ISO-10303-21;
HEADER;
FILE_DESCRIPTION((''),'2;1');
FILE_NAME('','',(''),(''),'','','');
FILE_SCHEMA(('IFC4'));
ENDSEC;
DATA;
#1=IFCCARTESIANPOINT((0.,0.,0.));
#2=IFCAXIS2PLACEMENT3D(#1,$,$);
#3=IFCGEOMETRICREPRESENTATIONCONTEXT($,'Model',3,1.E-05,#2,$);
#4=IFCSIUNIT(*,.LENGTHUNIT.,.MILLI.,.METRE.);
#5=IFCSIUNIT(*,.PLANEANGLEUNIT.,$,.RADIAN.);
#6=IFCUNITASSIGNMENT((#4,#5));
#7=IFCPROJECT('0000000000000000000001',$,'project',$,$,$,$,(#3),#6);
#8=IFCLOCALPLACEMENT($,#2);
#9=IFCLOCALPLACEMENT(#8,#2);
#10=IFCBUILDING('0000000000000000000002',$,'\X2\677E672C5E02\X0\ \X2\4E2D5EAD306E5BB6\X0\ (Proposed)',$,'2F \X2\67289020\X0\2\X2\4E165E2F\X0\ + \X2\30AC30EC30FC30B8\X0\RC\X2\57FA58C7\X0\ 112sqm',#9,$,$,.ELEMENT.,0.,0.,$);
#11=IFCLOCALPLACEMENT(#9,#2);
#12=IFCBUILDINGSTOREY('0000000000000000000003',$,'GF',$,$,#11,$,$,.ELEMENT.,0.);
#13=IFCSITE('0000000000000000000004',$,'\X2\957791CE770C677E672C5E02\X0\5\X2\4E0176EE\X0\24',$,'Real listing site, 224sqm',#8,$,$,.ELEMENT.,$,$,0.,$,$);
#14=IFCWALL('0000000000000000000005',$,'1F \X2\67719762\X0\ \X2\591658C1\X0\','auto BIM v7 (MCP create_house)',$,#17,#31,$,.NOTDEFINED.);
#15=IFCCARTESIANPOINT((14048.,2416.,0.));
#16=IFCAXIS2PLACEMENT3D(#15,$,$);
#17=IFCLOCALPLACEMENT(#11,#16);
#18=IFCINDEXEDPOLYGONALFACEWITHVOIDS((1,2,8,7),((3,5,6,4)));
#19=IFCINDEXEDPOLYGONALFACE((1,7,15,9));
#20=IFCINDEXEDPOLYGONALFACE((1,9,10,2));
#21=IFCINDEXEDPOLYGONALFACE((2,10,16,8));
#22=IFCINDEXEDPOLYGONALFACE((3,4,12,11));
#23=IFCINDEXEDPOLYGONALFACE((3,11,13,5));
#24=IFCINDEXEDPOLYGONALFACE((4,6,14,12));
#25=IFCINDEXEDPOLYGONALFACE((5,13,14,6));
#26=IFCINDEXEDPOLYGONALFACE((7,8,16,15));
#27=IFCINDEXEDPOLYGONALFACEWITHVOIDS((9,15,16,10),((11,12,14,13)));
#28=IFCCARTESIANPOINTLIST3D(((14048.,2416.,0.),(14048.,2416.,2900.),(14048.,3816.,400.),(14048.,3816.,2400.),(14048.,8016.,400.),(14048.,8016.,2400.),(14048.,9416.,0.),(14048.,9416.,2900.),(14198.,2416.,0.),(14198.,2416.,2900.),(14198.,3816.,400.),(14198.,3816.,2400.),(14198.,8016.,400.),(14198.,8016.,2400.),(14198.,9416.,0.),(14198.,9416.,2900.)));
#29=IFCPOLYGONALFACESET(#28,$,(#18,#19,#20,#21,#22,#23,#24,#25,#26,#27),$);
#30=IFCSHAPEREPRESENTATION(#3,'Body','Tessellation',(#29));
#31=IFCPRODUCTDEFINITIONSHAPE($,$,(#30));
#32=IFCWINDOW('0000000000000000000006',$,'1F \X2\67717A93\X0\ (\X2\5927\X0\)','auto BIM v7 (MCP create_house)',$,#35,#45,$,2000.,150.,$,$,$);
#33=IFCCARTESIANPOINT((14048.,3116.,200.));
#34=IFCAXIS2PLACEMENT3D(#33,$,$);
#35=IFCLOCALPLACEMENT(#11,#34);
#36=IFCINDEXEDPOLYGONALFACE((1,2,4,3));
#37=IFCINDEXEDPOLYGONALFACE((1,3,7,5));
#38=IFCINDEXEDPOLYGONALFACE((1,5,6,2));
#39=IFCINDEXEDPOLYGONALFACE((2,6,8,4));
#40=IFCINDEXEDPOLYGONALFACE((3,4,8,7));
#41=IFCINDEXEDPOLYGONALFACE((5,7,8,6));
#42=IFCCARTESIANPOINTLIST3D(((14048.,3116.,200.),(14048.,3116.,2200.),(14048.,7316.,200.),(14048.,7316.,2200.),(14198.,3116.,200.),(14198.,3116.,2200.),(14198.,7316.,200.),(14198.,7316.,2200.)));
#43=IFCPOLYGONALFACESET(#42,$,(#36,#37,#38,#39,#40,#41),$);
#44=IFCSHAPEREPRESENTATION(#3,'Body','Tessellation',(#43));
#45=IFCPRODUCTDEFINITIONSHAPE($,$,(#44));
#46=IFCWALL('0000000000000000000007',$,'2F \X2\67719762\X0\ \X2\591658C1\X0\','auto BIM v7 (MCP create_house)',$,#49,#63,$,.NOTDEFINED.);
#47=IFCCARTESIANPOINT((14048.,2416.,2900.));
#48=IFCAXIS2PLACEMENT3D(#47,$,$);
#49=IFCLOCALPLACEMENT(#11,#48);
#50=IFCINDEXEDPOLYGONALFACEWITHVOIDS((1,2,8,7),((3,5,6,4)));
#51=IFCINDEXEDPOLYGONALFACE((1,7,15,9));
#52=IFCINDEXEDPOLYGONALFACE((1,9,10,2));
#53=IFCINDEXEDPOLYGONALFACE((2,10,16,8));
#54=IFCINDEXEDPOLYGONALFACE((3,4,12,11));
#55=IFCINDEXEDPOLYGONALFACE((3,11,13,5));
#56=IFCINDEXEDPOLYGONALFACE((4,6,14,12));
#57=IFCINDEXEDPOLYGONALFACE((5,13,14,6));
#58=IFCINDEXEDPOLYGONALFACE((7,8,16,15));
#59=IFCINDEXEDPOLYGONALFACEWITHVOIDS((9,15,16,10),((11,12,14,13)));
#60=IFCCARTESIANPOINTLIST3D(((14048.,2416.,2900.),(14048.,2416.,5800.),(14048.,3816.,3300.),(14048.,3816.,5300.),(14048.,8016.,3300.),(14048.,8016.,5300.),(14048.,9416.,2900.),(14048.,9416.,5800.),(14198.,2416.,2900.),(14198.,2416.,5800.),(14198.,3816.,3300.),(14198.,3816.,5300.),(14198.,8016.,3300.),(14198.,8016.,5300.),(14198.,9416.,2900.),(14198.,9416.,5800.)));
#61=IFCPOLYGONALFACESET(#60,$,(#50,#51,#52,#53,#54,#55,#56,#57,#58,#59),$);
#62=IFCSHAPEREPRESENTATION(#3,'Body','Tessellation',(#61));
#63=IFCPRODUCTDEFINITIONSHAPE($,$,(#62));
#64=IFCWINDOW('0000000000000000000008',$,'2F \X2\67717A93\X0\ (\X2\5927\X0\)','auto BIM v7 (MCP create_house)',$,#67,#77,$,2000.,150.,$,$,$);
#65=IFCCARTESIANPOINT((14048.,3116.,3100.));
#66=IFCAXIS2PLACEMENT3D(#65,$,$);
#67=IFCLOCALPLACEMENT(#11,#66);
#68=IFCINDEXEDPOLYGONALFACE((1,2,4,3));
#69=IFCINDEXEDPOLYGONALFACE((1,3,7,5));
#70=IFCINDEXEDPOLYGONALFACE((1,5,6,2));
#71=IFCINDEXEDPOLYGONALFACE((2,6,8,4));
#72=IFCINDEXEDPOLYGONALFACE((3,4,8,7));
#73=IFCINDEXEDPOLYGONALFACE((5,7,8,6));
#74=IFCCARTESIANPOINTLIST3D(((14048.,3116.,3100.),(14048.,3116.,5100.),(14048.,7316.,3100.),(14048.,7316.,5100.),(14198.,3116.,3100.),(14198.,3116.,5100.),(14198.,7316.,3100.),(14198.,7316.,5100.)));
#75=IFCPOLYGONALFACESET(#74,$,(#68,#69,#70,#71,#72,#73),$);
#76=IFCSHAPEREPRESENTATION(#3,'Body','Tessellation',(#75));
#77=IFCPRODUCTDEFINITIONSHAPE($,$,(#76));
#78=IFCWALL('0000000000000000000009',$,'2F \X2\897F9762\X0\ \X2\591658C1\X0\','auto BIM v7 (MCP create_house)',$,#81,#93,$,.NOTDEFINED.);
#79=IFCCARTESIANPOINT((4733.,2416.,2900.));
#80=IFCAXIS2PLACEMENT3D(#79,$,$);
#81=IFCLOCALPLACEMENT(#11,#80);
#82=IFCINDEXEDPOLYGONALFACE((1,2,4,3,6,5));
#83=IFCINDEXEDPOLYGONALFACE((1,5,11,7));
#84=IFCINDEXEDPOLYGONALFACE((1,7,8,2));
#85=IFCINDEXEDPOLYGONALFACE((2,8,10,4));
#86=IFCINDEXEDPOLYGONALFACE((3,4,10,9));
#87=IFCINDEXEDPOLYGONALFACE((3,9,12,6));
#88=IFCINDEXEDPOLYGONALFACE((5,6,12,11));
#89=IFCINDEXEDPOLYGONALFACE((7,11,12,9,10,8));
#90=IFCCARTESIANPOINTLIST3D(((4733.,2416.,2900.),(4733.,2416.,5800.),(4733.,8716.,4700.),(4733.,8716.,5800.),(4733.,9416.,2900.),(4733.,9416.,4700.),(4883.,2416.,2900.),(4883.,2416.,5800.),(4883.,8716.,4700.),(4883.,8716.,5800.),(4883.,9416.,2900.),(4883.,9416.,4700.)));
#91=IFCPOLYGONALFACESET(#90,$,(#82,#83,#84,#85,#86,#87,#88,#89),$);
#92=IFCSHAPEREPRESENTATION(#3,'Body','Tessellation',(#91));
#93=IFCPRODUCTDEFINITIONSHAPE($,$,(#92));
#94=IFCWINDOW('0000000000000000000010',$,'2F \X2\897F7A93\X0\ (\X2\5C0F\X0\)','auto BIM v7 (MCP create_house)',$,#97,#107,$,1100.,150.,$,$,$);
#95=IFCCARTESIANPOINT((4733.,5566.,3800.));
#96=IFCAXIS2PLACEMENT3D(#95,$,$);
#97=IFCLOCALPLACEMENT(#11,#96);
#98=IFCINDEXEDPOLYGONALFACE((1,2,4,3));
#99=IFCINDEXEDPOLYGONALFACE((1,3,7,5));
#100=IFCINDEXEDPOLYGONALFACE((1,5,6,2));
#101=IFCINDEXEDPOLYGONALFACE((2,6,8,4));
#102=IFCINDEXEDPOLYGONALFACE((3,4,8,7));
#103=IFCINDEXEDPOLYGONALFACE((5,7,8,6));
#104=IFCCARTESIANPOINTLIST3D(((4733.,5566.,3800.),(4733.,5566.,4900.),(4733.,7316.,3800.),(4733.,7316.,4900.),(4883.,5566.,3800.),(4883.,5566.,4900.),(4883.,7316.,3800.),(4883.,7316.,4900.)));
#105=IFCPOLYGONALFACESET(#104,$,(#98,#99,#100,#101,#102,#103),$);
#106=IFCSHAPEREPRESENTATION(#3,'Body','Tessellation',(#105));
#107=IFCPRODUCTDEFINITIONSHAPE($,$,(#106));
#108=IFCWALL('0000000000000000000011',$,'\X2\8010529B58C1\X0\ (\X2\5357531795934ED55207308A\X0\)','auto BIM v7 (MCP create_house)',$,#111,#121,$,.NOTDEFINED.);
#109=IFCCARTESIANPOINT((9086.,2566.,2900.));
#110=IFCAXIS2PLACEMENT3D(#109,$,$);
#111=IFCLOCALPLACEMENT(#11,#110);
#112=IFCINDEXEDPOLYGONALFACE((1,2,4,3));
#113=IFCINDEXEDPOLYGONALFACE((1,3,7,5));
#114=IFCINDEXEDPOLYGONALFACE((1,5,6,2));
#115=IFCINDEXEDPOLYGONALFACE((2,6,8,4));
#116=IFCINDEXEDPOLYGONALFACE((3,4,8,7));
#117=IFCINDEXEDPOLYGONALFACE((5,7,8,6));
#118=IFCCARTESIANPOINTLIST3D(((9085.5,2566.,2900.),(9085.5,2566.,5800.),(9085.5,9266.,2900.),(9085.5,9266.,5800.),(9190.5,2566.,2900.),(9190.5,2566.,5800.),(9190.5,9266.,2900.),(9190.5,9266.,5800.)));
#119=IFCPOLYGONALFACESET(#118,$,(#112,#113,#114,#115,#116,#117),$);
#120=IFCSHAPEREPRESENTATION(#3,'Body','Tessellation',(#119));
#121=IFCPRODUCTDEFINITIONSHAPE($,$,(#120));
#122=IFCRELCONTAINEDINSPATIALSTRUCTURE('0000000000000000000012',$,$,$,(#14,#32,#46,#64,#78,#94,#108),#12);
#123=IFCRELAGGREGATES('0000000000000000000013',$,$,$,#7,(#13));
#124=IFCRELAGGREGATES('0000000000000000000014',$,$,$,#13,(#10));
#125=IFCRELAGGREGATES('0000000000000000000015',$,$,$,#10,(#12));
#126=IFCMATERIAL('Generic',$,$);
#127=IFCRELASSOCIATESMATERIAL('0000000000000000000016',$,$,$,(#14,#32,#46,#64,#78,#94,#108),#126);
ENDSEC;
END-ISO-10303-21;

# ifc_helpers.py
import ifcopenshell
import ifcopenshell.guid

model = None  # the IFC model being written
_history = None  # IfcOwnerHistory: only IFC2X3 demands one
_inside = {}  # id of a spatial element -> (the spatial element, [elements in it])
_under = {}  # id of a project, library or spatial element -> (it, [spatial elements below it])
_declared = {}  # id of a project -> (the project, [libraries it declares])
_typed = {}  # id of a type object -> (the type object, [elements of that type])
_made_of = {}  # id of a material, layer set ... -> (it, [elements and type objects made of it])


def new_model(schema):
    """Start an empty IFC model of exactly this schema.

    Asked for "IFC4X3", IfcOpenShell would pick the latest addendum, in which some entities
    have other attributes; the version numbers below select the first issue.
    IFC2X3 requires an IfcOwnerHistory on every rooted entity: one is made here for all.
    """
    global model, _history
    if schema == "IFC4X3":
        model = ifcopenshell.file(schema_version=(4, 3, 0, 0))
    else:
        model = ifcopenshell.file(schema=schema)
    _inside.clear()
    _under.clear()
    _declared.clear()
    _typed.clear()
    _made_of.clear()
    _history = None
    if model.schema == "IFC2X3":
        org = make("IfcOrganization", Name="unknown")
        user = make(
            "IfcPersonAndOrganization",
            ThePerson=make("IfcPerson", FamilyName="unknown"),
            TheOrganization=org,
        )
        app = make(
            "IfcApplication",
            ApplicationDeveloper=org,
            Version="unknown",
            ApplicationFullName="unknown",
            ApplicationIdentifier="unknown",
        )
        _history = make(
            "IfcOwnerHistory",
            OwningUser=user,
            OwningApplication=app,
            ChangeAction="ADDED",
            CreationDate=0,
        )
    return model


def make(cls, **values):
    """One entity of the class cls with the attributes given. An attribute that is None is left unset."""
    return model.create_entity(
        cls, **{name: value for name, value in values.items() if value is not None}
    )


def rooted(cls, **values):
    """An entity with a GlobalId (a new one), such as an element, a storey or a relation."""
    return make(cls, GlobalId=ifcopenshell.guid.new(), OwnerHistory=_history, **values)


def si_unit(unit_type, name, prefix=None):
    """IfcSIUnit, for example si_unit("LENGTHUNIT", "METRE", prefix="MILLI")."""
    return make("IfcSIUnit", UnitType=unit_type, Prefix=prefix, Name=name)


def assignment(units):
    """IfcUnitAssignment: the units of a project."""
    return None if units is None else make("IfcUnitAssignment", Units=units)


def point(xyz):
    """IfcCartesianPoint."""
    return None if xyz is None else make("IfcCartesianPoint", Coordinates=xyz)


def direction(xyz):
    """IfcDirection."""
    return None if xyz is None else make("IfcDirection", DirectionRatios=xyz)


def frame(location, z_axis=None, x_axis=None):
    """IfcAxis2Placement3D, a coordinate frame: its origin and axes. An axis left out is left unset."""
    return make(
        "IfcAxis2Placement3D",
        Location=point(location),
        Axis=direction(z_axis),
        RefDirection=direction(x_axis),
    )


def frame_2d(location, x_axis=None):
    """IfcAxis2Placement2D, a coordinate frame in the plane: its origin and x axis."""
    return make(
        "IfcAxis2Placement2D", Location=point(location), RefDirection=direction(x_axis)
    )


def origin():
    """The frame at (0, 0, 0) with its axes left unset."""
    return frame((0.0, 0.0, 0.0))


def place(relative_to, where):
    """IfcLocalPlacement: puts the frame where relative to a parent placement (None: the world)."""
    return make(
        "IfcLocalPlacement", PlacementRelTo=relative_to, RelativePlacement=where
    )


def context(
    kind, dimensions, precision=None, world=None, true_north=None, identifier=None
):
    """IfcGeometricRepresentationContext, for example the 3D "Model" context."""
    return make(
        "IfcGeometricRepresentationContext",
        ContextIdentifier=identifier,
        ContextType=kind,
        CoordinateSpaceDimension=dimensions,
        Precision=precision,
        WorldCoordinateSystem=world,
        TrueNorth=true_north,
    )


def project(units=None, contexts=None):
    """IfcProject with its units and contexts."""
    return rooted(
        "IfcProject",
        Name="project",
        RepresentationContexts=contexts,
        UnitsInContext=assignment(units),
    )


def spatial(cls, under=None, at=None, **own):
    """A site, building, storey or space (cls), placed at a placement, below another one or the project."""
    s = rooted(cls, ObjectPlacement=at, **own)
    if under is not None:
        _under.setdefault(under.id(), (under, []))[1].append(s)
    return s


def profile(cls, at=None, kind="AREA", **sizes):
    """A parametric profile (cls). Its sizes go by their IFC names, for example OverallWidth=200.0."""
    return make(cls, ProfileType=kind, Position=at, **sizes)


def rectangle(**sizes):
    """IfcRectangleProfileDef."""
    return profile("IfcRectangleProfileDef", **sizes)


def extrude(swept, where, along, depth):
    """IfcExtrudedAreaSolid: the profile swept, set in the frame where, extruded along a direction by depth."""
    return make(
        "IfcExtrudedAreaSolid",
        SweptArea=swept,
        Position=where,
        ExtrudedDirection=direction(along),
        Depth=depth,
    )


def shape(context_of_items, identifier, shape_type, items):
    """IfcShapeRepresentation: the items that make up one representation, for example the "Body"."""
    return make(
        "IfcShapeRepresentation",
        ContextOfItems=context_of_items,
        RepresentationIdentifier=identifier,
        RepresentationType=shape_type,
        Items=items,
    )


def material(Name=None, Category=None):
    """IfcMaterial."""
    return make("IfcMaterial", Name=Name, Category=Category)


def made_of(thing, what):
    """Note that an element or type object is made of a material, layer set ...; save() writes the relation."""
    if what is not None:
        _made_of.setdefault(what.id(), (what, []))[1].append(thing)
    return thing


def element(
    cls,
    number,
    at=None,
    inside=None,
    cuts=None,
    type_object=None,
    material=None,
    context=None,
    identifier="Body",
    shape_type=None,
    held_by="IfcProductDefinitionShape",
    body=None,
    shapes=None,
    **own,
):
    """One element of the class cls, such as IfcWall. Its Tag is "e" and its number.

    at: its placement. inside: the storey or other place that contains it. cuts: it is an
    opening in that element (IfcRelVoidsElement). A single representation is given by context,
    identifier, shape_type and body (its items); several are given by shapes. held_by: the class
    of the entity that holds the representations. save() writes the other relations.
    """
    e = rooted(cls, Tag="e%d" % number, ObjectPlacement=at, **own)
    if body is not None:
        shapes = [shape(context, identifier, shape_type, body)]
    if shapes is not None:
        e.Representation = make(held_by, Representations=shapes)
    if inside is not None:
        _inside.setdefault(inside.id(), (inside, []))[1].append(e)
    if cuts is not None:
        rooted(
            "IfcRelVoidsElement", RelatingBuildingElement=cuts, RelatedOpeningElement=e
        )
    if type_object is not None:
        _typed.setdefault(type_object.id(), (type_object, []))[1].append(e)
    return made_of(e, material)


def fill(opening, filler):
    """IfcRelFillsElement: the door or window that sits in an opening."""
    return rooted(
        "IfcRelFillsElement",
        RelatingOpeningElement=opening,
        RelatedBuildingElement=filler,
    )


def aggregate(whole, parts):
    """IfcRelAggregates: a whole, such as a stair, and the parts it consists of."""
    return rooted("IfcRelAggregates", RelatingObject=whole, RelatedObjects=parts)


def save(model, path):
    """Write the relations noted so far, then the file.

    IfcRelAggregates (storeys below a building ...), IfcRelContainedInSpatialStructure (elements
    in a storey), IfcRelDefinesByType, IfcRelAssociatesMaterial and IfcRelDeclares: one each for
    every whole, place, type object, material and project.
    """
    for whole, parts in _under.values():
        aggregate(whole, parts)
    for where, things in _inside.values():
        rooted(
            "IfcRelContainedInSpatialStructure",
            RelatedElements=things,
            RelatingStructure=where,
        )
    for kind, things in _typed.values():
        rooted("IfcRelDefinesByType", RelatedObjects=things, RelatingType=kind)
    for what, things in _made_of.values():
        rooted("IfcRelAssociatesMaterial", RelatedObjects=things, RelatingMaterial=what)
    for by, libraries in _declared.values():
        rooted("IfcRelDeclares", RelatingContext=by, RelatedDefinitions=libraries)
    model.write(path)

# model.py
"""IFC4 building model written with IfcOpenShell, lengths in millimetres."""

from ifc_helpers import new_model, si_unit, frame, frame_2d, origin, place, context, project, spatial, rectangle, extrude, material, element, fill, save


model = new_model("IFC4")

# Units and contexts
model_context = context("Model", 3, precision=1e-05, world=origin())
ifc_project = project(units=[si_unit("LENGTHUNIT", "METRE", prefix="MILLI"), si_unit("PLANEANGLEUNIT", "RADIAN")], contexts=[model_context])

# Site, building, storey
site_placement = place(None, origin())
site = spatial("IfcSite", under=ifc_project, at=site_placement, Name="長野県松本市5丁目24", ObjectType="Real listing site, 224sqm", CompositionType="ELEMENT", RefElevation=0.0)
building_placement = place(site_placement, origin())
building = spatial("IfcBuilding", under=site, at=building_placement, Name="松本市 中庭の家 (Proposed)", ObjectType="2F 木造2世帯 + ガレージRC基壇 112sqm", CompositionType="ELEMENT", ElevationOfRefHeight=0.0, ElevationOfTerrain=0.0)
storey_placement = place(building_placement, origin())
storey = spatial("IfcBuildingStorey", under=building, at=storey_placement, Name="GF", CompositionType="ELEMENT", Elevation=0.0)

# Shared definitions
ifc_material = material(Name="Generic")

# Wall, opening, window
wall_1_placement = place(storey_placement, frame((14048.0, 2416.0, 0.0)))
wall_1 = element("IfcWall", 1, at=wall_1_placement, inside=storey, material=ifc_material, Name="1F 東面 外壁", Description="auto BIM v7 (MCP create_house)", PredefinedType="NOTDEFINED", context=model_context, shape_type="SweptSolid", body=[
    extrude(rectangle(XDim=150.0, YDim=7000.0, at=frame_2d((75.0, 3500.0))), frame((14048.0, 2416.0, 0.0)), (0.0, 0.0, 1.0), 2900.0),
])
opening_1_placement = place(storey_placement, frame((14048.0, 3116.0, 200.0)))
opening_1 = element("IfcOpeningElement", 2, at=opening_1_placement, cuts=wall_1, PredefinedType="NOTDEFINED", context=model_context, shape_type="SweptSolid", body=[
    extrude(rectangle(XDim=150.0, YDim=4200.0, at=frame_2d((75.0, 2100.0))), frame((14048.0, 3116.0, 200.0)), (0.0, 0.0, 1.0), 2000.0),
])
window_1_placement = place(storey_placement, frame((14048.0, 3116.0, 200.0)))
window_1 = element("IfcWindow", 3, at=window_1_placement, inside=storey, material=ifc_material, Name="1F 東窓 (大)", Description="auto BIM v7 (MCP create_house)", OverallHeight=2000.0, OverallWidth=150.0, context=model_context, shape_type="SweptSolid", body=[
    extrude(rectangle(XDim=150.0, YDim=4200.0, at=frame_2d((75.0, 2100.0))), frame((14048.0, 3116.0, 200.0)), (0.0, 0.0, 1.0), 2000.0),
])
fill(opening_1, window_1)

# Walls, openings, windows
wall_2_placement = place(storey_placement, frame((14048.0, 2416.0, 2900.0)))
wall_2 = element("IfcWall", 4, at=wall_2_placement, inside=storey, material=ifc_material, Name="2F 東面 外壁", Description="auto BIM v7 (MCP create_house)", PredefinedType="NOTDEFINED", context=model_context, shape_type="SweptSolid", body=[
    extrude(rectangle(XDim=150.0, YDim=7000.0, at=frame_2d((75.0, 3500.0))), frame((14048.0, 2416.0, 2900.0)), (0.0, 0.0, 1.0), 2900.0),
])
opening_2_placement = place(storey_placement, frame((14048.0, 3116.0, 3100.0)))
opening_2 = element("IfcOpeningElement", 5, at=opening_2_placement, cuts=wall_2, PredefinedType="NOTDEFINED", context=model_context, shape_type="SweptSolid", body=[
    extrude(rectangle(XDim=150.0, YDim=4200.0, at=frame_2d((75.0, 2100.0))), frame((14048.0, 3116.0, 3100.0)), (0.0, 0.0, 1.0), 2000.0),
])
window_2_placement = place(storey_placement, frame((14048.0, 3116.0, 3100.0)))
window_2 = element("IfcWindow", 6, at=window_2_placement, inside=storey, material=ifc_material, Name="2F 東窓 (大)", Description="auto BIM v7 (MCP create_house)", OverallHeight=2000.0, OverallWidth=150.0, context=model_context, shape_type="SweptSolid", body=[
    extrude(rectangle(XDim=150.0, YDim=4200.0, at=frame_2d((75.0, 2100.0))), frame((14048.0, 3116.0, 3100.0)), (0.0, 0.0, 1.0), 2000.0),
])
fill(opening_2, window_2)
wall_3_placement = place(storey_placement, frame((4733.0, 2416.0, 2900.0)))
wall_3 = element("IfcWall", 7, at=wall_3_placement, inside=storey, material=ifc_material, Name="2F 西面 外壁", Description="auto BIM v7 (MCP create_house)", PredefinedType="NOTDEFINED", context=model_context, shape_type="SweptSolid", body=[
    extrude(rectangle(XDim=150.0, YDim=7000.0, at=frame_2d((75.0, 3500.0))), frame((4733.0, 2416.0, 2900.0)), (0.0, 0.0, 1.0), 2900.0),
])
opening_3_placement = place(storey_placement, frame((4733.0, 5566.0, 3800.0)))
opening_3 = element("IfcOpeningElement", 8, at=opening_3_placement, cuts=wall_3, PredefinedType="NOTDEFINED", context=model_context, shape_type="SweptSolid", body=[
    extrude(rectangle(XDim=150.0, YDim=1750.0, at=frame_2d((75.0, 875.0))), frame((4733.0, 5566.0, 3800.0)), (0.0, 0.0, 1.0), 1100.0),
])
window_3_placement = place(storey_placement, frame((4733.0, 5566.0, 3800.0)))
window_3 = element("IfcWindow", 9, at=window_3_placement, inside=storey, material=ifc_material, Name="2F 西窓 (小)", Description="auto BIM v7 (MCP create_house)", OverallHeight=1100.0, OverallWidth=150.0, context=model_context, shape_type="SweptSolid", body=[
    extrude(rectangle(XDim=150.0, YDim=1750.0, at=frame_2d((75.0, 875.0))), frame((4733.0, 5566.0, 3800.0)), (0.0, 0.0, 1.0), 1100.0),
])
fill(opening_3, window_3)

# Wall
wall_4_placement = place(storey_placement, frame((9086.0, 2566.0, 2900.0)))
element("IfcWall", 10, at=wall_4_placement, inside=storey, material=ifc_material, Name="耐力壁 (南北間仕切り)", Description="auto BIM v7 (MCP create_house)", PredefinedType="NOTDEFINED", context=model_context, shape_type="SweptSolid", body=[
    extrude(rectangle(XDim=105.0, YDim=6700.0, at=frame_2d((52.0, 3350.0))), frame((9086.0, 2566.0, 2900.0)), (0.0, 0.0, 1.0), 2900.0),
])

save(model, "model.ifc")
